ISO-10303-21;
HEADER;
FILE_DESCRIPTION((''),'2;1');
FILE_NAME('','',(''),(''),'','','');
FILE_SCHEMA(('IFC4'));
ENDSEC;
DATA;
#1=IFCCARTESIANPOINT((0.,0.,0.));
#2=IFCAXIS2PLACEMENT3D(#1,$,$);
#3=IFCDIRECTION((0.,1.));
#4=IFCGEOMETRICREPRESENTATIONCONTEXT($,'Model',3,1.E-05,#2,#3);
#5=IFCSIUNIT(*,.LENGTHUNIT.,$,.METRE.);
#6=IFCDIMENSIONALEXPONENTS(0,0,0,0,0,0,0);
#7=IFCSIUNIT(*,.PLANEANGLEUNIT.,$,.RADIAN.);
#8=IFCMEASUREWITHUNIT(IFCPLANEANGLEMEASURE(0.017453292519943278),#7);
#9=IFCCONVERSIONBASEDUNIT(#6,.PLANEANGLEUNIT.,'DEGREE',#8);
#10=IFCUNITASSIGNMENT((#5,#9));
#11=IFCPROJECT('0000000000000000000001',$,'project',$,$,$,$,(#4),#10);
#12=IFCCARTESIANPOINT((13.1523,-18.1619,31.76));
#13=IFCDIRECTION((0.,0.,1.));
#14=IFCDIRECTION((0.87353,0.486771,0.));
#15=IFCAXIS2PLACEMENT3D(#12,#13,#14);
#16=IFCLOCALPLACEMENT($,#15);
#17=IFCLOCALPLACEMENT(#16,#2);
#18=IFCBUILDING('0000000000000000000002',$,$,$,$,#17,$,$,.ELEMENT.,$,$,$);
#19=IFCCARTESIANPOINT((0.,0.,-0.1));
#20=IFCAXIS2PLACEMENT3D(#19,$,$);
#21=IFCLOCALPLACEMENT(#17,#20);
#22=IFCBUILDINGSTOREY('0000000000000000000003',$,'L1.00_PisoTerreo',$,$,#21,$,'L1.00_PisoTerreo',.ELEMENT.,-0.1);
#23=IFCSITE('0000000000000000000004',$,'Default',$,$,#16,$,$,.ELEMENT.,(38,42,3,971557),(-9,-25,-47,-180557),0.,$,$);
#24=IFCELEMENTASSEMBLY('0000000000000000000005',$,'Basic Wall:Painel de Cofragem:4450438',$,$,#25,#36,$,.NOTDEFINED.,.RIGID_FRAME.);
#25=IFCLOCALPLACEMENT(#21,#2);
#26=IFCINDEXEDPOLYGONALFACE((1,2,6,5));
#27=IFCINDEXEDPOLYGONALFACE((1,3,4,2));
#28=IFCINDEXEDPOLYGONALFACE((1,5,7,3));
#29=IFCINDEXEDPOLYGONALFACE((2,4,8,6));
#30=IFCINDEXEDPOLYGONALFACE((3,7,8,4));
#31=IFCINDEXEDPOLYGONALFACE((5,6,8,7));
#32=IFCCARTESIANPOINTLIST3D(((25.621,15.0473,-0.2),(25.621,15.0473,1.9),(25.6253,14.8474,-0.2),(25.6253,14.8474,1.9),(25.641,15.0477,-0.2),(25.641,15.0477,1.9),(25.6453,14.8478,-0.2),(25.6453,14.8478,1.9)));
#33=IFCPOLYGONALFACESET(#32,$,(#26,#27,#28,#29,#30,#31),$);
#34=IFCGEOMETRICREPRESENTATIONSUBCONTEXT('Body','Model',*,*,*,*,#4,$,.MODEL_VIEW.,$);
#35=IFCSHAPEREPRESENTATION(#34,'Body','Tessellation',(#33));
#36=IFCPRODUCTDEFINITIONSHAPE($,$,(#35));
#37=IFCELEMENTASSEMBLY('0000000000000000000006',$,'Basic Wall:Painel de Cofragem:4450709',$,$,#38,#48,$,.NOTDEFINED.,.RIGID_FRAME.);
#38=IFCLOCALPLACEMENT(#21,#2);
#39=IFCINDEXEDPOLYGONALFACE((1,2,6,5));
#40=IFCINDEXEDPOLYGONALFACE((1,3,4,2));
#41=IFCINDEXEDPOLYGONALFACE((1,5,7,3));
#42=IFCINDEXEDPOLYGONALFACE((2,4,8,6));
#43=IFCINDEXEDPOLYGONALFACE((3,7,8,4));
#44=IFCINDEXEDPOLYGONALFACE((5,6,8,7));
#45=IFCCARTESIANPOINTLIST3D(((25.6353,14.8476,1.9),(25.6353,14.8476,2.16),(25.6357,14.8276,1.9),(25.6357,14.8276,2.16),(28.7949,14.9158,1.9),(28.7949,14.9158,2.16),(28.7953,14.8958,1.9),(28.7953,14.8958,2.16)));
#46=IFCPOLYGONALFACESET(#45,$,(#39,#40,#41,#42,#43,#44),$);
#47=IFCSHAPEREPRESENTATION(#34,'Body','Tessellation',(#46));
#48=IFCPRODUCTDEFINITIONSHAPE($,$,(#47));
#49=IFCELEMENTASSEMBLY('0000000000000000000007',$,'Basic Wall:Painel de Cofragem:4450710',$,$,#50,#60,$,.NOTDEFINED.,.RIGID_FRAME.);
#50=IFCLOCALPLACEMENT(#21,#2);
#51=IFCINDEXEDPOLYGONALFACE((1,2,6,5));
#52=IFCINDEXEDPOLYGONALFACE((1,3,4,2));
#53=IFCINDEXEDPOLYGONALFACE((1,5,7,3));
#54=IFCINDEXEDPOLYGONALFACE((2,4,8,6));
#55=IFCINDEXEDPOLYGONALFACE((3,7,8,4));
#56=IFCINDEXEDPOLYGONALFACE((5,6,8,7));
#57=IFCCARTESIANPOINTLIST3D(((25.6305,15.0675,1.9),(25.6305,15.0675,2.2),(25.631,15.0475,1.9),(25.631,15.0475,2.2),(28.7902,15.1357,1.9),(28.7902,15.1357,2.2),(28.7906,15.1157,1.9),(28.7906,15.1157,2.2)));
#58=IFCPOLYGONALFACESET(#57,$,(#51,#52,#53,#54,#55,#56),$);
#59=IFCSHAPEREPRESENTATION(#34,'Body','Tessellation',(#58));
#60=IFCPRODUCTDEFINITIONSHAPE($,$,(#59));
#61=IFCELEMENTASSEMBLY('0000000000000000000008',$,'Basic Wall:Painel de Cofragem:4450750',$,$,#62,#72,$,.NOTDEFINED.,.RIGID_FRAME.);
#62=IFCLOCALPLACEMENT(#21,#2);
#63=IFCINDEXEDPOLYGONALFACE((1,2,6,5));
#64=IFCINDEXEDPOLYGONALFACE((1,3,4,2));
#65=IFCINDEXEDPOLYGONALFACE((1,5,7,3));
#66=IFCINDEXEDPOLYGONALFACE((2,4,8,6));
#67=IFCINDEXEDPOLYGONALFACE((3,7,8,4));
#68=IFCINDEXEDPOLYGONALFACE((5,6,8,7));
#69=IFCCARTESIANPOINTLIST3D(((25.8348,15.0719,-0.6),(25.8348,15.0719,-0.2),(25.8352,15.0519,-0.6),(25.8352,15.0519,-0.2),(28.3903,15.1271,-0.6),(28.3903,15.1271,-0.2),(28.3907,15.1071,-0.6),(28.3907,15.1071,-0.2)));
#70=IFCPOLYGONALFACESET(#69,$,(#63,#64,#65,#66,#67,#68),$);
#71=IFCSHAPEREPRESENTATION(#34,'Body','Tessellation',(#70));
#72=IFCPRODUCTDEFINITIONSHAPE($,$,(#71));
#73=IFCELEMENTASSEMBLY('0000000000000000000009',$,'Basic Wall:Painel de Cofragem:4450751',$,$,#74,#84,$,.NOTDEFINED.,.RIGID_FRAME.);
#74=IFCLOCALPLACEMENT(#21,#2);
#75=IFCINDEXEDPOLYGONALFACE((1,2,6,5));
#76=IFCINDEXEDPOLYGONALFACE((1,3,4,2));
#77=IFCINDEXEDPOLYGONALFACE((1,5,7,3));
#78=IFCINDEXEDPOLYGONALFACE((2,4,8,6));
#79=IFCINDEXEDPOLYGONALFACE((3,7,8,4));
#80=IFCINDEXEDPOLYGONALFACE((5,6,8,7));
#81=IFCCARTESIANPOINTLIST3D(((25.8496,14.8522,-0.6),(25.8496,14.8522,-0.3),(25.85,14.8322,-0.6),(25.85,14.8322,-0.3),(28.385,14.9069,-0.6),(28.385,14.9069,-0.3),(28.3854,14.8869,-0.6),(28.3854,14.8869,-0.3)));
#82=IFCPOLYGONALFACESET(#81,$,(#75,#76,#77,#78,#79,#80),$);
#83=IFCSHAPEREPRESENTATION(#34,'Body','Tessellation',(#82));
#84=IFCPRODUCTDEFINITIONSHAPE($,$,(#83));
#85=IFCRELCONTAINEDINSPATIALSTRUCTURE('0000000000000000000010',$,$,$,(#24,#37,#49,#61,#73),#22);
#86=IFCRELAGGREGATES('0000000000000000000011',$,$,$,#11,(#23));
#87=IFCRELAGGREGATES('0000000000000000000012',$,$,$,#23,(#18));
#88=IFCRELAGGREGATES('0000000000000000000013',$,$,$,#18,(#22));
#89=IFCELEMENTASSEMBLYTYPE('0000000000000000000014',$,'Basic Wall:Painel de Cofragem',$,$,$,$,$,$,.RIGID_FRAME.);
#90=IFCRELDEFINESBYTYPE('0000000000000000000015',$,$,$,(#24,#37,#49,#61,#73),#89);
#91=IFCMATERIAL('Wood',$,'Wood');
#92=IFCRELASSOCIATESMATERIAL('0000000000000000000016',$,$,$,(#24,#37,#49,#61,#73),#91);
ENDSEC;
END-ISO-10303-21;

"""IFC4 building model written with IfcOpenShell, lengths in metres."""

from ifc_helpers import new_model, entity, si_unit, converted_unit, direction, frame, origin, place, context, subcontext, project, spatial, indexed_curve, outline, extrude, material, type_object, element, save


model = new_model("IFC4")

# Units and contexts
model_context = context("Model", 3, precision=1e-05, world=origin(), true_north=direction((0.0, 1.0)))
body_context = subcontext(model_context, "Body", "Model", "MODEL_VIEW")
ifc_project = project(units=[si_unit("LENGTHUNIT", "METRE"), converted_unit("PLANEANGLEUNIT", "DEGREE", entity("IfcPlaneAngleMeasure", 0.017453292519943278), si_unit("PLANEANGLEUNIT", "RADIAN"), dimensions=[0, 0, 0, 0, 0, 0, 0])], contexts=[model_context])

# Site, building, storey
site_placement = place(None, frame((13.1523, -18.1619, 31.76), z_axis=(0.0, 0.0, 1.0), x_axis=(0.87353, 0.486771, 0.0)))
site = spatial("IfcSite", under=ifc_project, at=site_placement, Name="Default", CompositionType="ELEMENT", RefLatitude=(38, 42, 3, 971557), RefLongitude=(-9, -25, -47, -180557), RefElevation=0.0)
building_placement = place(site_placement, origin())
building = spatial("IfcBuilding", under=site, at=building_placement, CompositionType="ELEMENT")
storey_placement = place(building_placement, frame((0.0, 0.0, -0.1)))
storey = spatial("IfcBuildingStorey", under=building, at=storey_placement, Name="L1.00_PisoTerreo", LongName="L1.00_PisoTerreo", CompositionType="ELEMENT", Elevation=-0.1)

# Element assemblies
ifc_material_1 = material(Name="Wood", Category="Wood")
element_assembly_type = type_object("IfcElementAssemblyType", Name="Basic Wall:Painel de Cofragem", PredefinedType="RIGID_FRAME")
assembly_1_placement = place(storey_placement, frame((25.631, 15.0475, -0.2), z_axis=(0.0, 0.0, 1.0), x_axis=(0.021581, -0.999767, 0.0)))
element("IfcElementAssembly", 1, at=assembly_1_placement, inside=storey, type_object=element_assembly_type, material=ifc_material_1, Name="Basic Wall:Painel de Cofragem:4450438", AssemblyPlace="NOTDEFINED", PredefinedType="RIGID_FRAME", context=body_context, shape_type="SweptSolid", body=[
    extrude(outline(indexed_curve([(0.2, 0.01), (0.0, 0.01), (0.0, -0.01), (0.2, -0.01), (0.2, 0.01)], self_intersect=False)), origin(), (0.0, 0.0, 1.0), 2.1),
])
assembly_2_placement = place(storey_placement, frame((25.6355, 14.8376, 1.9), z_axis=(0.0, 0.0, 1.0), x_axis=(0.999767, 0.021581, 0.0)))
element("IfcElementAssembly", 2, at=assembly_2_placement, inside=storey, type_object=element_assembly_type, material=ifc_material_1, Name="Basic Wall:Painel de Cofragem:4450709", AssemblyPlace="NOTDEFINED", PredefinedType="RIGID_FRAME", context=body_context, shape_type="SweptSolid", body=[
    extrude(outline(indexed_curve([(3.1604, 0.01), (0.0, 0.01), (0.0, -0.01), (3.1604, -0.01), (3.1604, 0.01)], self_intersect=False)), origin(), (0.0, 0.0, 1.0), 0.26),
])
assembly_3_placement = place(storey_placement, frame((25.6308, 15.0575, 1.9), z_axis=(0.0, 0.0, 1.0), x_axis=(0.999767, 0.021581, 0.0)))
element("IfcElementAssembly", 3, at=assembly_3_placement, inside=storey, type_object=element_assembly_type, material=ifc_material_1, Name="Basic Wall:Painel de Cofragem:4450710", AssemblyPlace="NOTDEFINED", PredefinedType="RIGID_FRAME", context=body_context, shape_type="SweptSolid", body=[
    extrude(outline(indexed_curve([(3.1604, 0.01), (0.0, 0.01), (0.0, -0.01), (3.1604, -0.01), (3.1604, 0.01)], self_intersect=False)), origin(), (0.0, 0.0, 1.0), 0.3),
])
assembly_4_placement = place(storey_placement, frame((25.835, 15.0619, -0.6), z_axis=(0.0, 0.0, 1.0), x_axis=(0.999767, 0.021581, 0.0)))
element("IfcElementAssembly", 4, at=assembly_4_placement, inside=storey, type_object=element_assembly_type, material=ifc_material_1, Name="Basic Wall:Painel de Cofragem:4450750", AssemblyPlace="NOTDEFINED", PredefinedType="RIGID_FRAME", context=body_context, shape_type="SweptSolid", body=[
    extrude(outline(indexed_curve([(2.556, 0.01), (0.0, 0.01), (0.0, -0.01), (2.556, -0.01), (2.556, 0.01)], self_intersect=False)), origin(), (0.0, 0.0, 1.0), 0.4),
])
assembly_5_placement = place(storey_placement, frame((25.8498, 14.8422, -0.6), z_axis=(0.0, 0.0, 1.0), x_axis=(0.999767, 0.021581, 0.0)))
element("IfcElementAssembly", 5, at=assembly_5_placement, inside=storey, type_object=element_assembly_type, material=ifc_material_1, Name="Basic Wall:Painel de Cofragem:4450751", AssemblyPlace="NOTDEFINED", PredefinedType="RIGID_FRAME", context=body_context, shape_type="SweptSolid", body=[
    extrude(outline(indexed_curve([(2.536, 0.01), (0.0, 0.01), (0.0, -0.01), (2.536, -0.01), (2.536, 0.01)], self_intersect=False)), origin(), (0.0, 0.0, 1.0), 0.3),
])

save(model, "model.ifc")
